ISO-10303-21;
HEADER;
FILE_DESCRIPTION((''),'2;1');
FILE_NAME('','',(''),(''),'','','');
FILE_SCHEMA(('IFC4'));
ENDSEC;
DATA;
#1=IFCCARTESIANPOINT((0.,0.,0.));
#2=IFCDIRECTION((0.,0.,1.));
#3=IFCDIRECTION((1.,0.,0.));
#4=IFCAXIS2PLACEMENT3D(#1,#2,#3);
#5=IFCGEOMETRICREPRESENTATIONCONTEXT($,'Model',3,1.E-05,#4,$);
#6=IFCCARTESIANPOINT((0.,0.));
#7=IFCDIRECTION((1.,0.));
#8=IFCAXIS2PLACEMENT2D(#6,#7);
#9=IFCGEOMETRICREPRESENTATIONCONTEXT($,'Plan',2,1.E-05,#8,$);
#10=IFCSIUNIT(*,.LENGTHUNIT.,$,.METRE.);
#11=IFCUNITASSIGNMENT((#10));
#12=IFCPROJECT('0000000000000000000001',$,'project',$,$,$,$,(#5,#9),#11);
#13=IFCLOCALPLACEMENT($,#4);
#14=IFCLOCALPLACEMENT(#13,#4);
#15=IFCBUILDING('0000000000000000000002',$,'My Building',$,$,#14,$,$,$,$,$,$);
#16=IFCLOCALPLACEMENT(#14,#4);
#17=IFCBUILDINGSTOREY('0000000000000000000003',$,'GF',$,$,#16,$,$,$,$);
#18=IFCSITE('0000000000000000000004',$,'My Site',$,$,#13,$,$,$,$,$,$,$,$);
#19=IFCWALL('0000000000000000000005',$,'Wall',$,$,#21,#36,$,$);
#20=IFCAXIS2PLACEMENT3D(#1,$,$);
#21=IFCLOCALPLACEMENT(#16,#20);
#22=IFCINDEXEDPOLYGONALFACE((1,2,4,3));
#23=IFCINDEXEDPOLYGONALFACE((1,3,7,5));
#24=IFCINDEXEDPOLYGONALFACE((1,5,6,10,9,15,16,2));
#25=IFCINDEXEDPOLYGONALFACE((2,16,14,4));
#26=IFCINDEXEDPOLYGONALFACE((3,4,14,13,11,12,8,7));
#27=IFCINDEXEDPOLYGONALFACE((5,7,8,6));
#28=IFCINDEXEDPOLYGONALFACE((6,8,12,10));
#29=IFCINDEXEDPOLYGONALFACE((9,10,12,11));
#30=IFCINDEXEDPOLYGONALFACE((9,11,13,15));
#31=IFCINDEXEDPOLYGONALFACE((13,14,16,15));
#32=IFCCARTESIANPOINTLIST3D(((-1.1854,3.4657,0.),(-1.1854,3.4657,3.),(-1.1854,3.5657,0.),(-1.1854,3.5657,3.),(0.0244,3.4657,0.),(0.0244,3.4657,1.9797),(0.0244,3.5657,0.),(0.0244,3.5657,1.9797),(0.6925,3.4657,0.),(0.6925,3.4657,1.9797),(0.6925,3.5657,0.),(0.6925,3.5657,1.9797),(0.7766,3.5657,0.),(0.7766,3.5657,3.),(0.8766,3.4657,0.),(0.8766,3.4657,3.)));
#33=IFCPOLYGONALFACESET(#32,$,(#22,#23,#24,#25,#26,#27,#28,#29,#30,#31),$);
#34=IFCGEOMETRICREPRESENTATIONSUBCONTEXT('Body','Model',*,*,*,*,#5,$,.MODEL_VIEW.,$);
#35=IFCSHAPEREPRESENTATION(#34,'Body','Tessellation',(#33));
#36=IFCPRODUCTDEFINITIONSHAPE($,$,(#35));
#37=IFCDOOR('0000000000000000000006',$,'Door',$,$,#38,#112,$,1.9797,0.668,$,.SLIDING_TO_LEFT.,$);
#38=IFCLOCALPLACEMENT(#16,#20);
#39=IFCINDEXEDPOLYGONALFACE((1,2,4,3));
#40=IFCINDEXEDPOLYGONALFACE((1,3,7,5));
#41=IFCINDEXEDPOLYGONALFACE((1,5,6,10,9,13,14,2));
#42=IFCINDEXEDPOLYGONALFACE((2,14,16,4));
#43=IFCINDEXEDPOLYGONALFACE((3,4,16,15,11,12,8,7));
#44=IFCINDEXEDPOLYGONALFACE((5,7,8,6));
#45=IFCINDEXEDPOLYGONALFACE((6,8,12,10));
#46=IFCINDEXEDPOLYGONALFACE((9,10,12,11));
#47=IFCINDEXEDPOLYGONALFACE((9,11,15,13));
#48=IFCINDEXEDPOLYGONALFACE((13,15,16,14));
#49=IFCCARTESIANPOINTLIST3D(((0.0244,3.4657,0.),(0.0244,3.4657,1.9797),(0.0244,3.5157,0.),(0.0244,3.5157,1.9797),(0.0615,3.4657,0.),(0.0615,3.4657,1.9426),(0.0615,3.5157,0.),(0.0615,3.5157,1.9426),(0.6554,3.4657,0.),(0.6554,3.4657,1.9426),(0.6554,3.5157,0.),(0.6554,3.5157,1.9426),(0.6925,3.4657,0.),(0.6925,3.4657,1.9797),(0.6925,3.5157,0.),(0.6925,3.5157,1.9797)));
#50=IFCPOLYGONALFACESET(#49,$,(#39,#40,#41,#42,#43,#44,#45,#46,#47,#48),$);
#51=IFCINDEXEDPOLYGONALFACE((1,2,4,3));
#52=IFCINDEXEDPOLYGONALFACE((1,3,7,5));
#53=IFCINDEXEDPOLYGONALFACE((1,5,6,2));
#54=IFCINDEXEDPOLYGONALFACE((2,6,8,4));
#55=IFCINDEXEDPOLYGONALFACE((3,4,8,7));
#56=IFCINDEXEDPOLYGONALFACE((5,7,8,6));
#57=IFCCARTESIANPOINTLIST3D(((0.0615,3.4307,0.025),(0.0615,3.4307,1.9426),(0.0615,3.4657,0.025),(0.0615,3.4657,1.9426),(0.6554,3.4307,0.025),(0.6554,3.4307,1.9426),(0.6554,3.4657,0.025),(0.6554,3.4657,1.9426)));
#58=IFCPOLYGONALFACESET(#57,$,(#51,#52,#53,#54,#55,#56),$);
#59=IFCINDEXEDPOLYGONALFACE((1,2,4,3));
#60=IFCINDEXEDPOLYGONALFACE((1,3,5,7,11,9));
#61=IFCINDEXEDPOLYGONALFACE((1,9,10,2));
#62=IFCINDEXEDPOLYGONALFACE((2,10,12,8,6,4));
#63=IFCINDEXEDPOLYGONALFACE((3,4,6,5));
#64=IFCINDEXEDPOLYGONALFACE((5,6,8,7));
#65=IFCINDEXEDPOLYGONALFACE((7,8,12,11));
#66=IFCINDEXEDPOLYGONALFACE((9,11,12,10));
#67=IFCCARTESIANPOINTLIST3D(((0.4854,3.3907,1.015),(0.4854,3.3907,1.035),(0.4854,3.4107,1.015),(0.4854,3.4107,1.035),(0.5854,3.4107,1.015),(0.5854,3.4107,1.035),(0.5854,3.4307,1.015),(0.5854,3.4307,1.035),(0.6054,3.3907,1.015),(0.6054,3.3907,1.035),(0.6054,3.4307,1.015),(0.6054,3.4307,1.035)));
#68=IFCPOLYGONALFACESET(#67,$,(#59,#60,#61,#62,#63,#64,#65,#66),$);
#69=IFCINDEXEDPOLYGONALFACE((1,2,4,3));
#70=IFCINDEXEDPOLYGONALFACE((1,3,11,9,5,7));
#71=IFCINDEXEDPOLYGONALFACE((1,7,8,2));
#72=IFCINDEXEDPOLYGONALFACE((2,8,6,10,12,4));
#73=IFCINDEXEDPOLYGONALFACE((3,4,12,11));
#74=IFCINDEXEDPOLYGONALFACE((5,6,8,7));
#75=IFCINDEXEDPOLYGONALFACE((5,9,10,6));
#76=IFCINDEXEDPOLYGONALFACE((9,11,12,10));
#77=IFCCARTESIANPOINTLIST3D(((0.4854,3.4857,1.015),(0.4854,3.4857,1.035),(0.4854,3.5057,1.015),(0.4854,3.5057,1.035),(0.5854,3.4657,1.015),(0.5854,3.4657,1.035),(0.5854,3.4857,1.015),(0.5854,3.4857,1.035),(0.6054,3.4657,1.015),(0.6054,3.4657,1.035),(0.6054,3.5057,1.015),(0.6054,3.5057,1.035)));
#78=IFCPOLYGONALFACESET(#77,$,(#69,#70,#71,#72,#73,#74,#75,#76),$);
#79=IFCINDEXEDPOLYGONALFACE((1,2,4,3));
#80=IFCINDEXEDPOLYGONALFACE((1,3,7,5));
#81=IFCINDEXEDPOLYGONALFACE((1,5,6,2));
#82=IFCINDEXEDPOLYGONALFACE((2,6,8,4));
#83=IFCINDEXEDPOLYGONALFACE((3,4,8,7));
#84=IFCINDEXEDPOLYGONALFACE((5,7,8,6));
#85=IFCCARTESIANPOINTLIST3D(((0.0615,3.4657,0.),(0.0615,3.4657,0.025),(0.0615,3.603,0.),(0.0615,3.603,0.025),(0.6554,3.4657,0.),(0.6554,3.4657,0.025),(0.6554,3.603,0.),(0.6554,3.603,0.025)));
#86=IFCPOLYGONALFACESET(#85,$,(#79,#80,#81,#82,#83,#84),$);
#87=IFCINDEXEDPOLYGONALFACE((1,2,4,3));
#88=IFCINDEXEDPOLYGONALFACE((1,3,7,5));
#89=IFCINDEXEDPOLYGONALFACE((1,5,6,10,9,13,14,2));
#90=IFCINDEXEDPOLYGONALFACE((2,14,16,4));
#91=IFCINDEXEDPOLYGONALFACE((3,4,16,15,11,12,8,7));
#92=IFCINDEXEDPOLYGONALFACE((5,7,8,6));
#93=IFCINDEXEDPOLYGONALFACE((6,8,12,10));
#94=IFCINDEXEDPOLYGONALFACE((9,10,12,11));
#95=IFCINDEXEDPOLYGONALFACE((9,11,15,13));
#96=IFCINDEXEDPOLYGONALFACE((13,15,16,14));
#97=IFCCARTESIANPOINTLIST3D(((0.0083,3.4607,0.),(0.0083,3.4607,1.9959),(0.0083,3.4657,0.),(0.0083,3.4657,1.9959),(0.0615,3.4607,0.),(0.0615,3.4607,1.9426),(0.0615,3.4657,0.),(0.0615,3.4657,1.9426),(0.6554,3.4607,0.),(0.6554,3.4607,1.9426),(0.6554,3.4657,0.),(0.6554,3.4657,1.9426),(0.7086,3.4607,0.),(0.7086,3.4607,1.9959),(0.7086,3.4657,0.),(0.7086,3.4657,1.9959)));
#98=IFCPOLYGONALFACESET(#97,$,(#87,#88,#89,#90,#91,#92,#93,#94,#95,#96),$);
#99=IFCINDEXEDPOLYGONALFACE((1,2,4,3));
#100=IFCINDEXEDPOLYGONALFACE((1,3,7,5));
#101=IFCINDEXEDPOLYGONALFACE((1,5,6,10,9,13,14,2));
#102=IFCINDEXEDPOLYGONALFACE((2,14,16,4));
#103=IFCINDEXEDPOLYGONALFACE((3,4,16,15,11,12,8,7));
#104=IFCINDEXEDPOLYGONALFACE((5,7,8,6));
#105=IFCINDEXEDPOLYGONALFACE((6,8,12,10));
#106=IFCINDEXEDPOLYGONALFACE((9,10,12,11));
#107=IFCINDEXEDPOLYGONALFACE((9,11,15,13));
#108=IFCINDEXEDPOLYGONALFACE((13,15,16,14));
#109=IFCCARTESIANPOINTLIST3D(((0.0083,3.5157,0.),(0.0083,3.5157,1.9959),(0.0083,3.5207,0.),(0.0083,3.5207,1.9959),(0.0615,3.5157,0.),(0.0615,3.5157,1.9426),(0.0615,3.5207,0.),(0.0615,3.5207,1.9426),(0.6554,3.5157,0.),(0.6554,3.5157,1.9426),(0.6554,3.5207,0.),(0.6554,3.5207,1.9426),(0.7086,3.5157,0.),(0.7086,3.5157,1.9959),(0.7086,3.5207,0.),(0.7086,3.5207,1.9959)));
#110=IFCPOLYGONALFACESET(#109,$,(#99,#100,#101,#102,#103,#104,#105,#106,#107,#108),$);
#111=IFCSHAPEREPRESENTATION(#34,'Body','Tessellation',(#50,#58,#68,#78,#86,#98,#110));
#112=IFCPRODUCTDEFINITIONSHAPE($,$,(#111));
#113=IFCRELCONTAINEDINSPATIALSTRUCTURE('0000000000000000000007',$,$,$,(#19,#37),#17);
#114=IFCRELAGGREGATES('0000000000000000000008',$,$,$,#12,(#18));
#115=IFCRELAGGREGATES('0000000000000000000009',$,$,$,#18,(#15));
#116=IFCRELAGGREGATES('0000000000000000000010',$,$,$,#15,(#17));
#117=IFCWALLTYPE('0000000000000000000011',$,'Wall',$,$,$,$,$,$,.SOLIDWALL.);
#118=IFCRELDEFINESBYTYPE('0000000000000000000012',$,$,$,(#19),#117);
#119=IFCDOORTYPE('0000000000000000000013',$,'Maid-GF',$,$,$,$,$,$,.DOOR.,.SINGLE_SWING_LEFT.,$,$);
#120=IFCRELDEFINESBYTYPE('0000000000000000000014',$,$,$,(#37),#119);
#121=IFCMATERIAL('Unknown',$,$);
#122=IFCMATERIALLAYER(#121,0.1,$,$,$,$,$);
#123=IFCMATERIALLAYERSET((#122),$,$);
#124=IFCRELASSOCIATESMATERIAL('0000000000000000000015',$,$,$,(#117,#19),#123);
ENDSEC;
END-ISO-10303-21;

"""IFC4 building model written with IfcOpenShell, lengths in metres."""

from ifc_helpers import new_model, entity, si_unit, frame, origin_with_axes, origin_2d_with_axis, place, context, subcontext, project, spatial, line, indexed_curve, outline, extrude, shape, source, transform, mapped, material, layer, layer_set, layer_usage, type_object, type_shapes, element, fill, save


model = new_model("IFC4")

# Units and contexts
model_context = context("Model", 3, precision=1e-05, world=origin_with_axes())
plan_context = context("Plan", 2, precision=1e-05, world=origin_2d_with_axis())
body_context_1 = subcontext(model_context, "Body", "Model", "MODEL_VIEW")
body_context_2 = subcontext(plan_context, "Body", "Plan", "PLAN_VIEW")
ifc_project = project(units=[si_unit("LENGTHUNIT", "METRE")], contexts=[model_context, plan_context])

# Site, building, storey
site_placement = place(None, origin_with_axes())
site = spatial("IfcSite", under=ifc_project, at=site_placement, Name="My Site")
building_placement = place(site_placement, origin_with_axes())
building = spatial("IfcBuilding", under=site, at=building_placement, Name="My Building")
storey_placement = place(building_placement, origin_with_axes())
storey = spatial("IfcBuildingStorey", under=building, at=storey_placement, Name="GF")

# Shared definitions
ifc_material = material(Name="Unknown")

# Shared definitions
ifc_layer_1 = layer(ifc_material, 0.1)
ifc_layer_set_1 = layer_set([ifc_layer_1])
wall_type = type_object("IfcWallType", Name="Wall", PredefinedType="SOLIDWALL", material=ifc_layer_set_1)

# Wall, opening, door
ifc_layer_usage_1 = layer_usage(ifc_layer_set_1, "AXIS2", "POSITIVE", 0.0)
wall_1_placement = place(storey_placement, frame((0.7766, 3.5657, 0.0), z_axis=(0.0, 0.0, 1.0), x_axis=(-1.0, 0.0, 0.0)))
wall_1 = element("IfcWall", 1, at=wall_1_placement, inside=storey, type_object=wall_type, material=ifc_layer_usage_1, Name="Wall", context=body_context_1, shape_type="SweptSolid", body=[
    extrude(outline(indexed_curve([(0.0, 0.0), (-0.1, 0.1), (1.962, 0.1), (1.962, 0.0)], segments=[line(1, 2, 3, 4, 1)])), origin_with_axes(), (0.0, 0.0, 1.0), 3.0),
])
shared_shape_1 = source(origin_with_axes(), body_context_1, "Body", "SweptSolid", [
    extrude(outline(indexed_curve([(0.0, 0.0), (0.668, 0.0), (0.668, 1.9797), (0.0, 1.9797)], segments=[line(1, 2, 3, 4, 1)])), frame((0.0, -0.6, 0.0), z_axis=(0.0, -1.0, 0.0), x_axis=(1.0, 0.0, 0.0)), (0.0, 0.0, -1.0), 1.2),
])
opening_1_placement = place(wall_1_placement, frame((0.7522, 0.1, 0.0), z_axis=(0.0, 0.0, 1.0), x_axis=(-1.0, 0.0, 0.0)))
opening_1 = element("IfcOpeningElement", 2, at=opening_1_placement, cuts=wall_1, PredefinedType="OPENING", context=body_context_1, shape_type="MappedRepresentation", body=[
    mapped(shared_shape_1, transform((0.0, 0.0, 0.0), x_axis=(1.0, 0.0, 0.0), y_axis=(0.0, 1.0, 0.0), z_axis=(0.0, 0.0, 1.0), scale=1.0)),
])
door_type_1 = type_object("IfcDoorType", Name="Maid-GF", OperationType="SINGLE_SWING_LEFT", PredefinedType="DOOR")
shared_shape_2 = source(origin_with_axes(), body_context_1, "Body", "SweptSolid", [
    extrude(outline(indexed_curve([(0.0, 0.0), (0.0, 1.9797), (0.668, 1.9797), (0.668, 0.0), (0.6309, 0.0), (0.6309, 1.9426), (0.0371, 1.9426), (0.0371, 0.0)], segments=[line(1, 2, 3, 4, 5, 6, 7, 8, 1)])), frame((0.0, 0.0, 0.0), z_axis=(0.0, -1.0, 0.0), x_axis=(1.0, 0.0, 0.0)), (0.0, 0.0, -1.0), 0.05),
    extrude(outline(indexed_curve([(0.0, 0.0), (0.5938, 0.0), (0.5938, 0.035), (0.0, 0.035)], segments=[line(1, 2, 3, 4, 1)])), frame((0.0371, -0.035, 0.025), z_axis=(0.0, 0.0, 1.0), x_axis=(1.0, 0.0, 0.0)), (0.0, 0.0, 1.0), 1.9176),
    extrude(outline(indexed_curve([(0.0, 0.0), (0.0, -0.04), (-0.12, -0.04), (-0.12, -0.02), (-0.02, -0.02), (-0.02, 0.0)], segments=[line(1, 2, 3, 4, 5, 6, 1)])), frame((0.5809, -0.035, 1.015), z_axis=(0.0, 0.0, 1.0), x_axis=(1.0, 0.0, 0.0)), (0.0, 0.0, 1.0), 0.02),
    extrude(outline(indexed_curve([(0.0, 0.0), (0.0, 0.04), (-0.12, 0.04), (-0.12, 0.02), (-0.02, 0.02), (-0.02, 0.0)], segments=[line(1, 2, 3, 4, 5, 6, 1)])), frame((0.5809, 0.0, 1.015), z_axis=(0.0, 0.0, 1.0), x_axis=(1.0, 0.0, 0.0)), (0.0, 0.0, 1.0), 0.02),
    extrude(outline(indexed_curve([(0.0, 0.0), (0.5938, 0.0), (0.5938, 0.1372), (0.0, 0.1372)], segments=[line(1, 2, 3, 4, 1)])), frame((0.0371, 0.0, 0.0), z_axis=(0.0, 0.0, 1.0), x_axis=(1.0, 0.0, 0.0)), (0.0, 0.0, 1.0), 0.025),
    extrude(outline(indexed_curve([(0.0, 0.0), (0.0, 1.9959), (0.7003, 1.9959), (0.7003, 0.0), (0.6471, 0.0), (0.6471, 1.9426), (0.0532, 1.9426), (0.0532, 0.0)], segments=[line(1, 2, 3, 4, 5, 6, 7, 8, 1)])), frame((-0.0162, -0.005, 0.0), z_axis=(0.0, -1.0, 0.0), x_axis=(1.0, 0.0, 0.0)), (0.0, 0.0, -1.0), 0.005),
    extrude(outline(indexed_curve([(0.0, 0.0), (0.0, 1.9959), (0.7003, 1.9959), (0.7003, 0.0), (0.6471, 0.0), (0.6471, 1.9426), (0.0532, 1.9426), (0.0532, 0.0)], segments=[line(1, 2, 3, 4, 5, 6, 7, 8, 1)])), frame((-0.0162, 0.05, 0.0), z_axis=(0.0, -1.0, 0.0), x_axis=(1.0, 0.0, 0.0)), (0.0, 0.0, -1.0), 0.005),
])
shared_shape_3 = source(origin_with_axes(), body_context_2, "Body", "Curve2D", [
    entity("IfcIndexedPolyCurve", entity("IfcCartesianPointList2D", [[0.0, 0.0], [0.0371, 0.0], [0.0371, 0.05], [0.0, 0.05]]), [entity("IfcLineIndex", [1, 2, 3, 4, 1])]),
    entity("IfcIndexedPolyCurve", entity("IfcCartesianPointList2D", [[0.668, 0.0], [0.6309, 0.0], [0.6309, 0.05], [0.668, 0.05]]), [entity("IfcLineIndex", [1, 2, 3, 4, 1])]),
    entity("IfcIndexedPolyCurve", entity("IfcCartesianPointList2D", [[-0.2598, -0.035], [0.334, -0.035], [0.334, 0.0], [-0.2598, 0.0]]), [entity("IfcLineIndex", [1, 2, 3, 4, 1])]),
])
type_shapes(door_type_1, [shared_shape_2, shared_shape_3])
door_1_placement = place(opening_1_placement, origin_with_axes())
door_1 = element("IfcDoor", 3, at=door_1_placement, inside=storey, type_object=door_type_1, Name="Door", OperationType="SLIDING_TO_LEFT", OverallHeight=1.9797, OverallWidth=0.668, shapes=[
    shape(body_context_1, "Body", "MappedRepresentation", [mapped(shared_shape_2, transform((0.0, 0.0, 0.0), x_axis=(1.0, 0.0, 0.0), y_axis=(0.0, 1.0, 0.0), z_axis=(0.0, 0.0, 1.0), scale=1.0))]),
    shape(body_context_2, "Body", "MappedRepresentation", [mapped(shared_shape_3, transform((0.0, 0.0, 0.0), x_axis=(1.0, 0.0, 0.0), y_axis=(0.0, 1.0, 0.0), z_axis=(0.0, 0.0, 1.0), scale=1.0))]),
])
fill(opening_1, door_1)

save(model, "model.ifc")
